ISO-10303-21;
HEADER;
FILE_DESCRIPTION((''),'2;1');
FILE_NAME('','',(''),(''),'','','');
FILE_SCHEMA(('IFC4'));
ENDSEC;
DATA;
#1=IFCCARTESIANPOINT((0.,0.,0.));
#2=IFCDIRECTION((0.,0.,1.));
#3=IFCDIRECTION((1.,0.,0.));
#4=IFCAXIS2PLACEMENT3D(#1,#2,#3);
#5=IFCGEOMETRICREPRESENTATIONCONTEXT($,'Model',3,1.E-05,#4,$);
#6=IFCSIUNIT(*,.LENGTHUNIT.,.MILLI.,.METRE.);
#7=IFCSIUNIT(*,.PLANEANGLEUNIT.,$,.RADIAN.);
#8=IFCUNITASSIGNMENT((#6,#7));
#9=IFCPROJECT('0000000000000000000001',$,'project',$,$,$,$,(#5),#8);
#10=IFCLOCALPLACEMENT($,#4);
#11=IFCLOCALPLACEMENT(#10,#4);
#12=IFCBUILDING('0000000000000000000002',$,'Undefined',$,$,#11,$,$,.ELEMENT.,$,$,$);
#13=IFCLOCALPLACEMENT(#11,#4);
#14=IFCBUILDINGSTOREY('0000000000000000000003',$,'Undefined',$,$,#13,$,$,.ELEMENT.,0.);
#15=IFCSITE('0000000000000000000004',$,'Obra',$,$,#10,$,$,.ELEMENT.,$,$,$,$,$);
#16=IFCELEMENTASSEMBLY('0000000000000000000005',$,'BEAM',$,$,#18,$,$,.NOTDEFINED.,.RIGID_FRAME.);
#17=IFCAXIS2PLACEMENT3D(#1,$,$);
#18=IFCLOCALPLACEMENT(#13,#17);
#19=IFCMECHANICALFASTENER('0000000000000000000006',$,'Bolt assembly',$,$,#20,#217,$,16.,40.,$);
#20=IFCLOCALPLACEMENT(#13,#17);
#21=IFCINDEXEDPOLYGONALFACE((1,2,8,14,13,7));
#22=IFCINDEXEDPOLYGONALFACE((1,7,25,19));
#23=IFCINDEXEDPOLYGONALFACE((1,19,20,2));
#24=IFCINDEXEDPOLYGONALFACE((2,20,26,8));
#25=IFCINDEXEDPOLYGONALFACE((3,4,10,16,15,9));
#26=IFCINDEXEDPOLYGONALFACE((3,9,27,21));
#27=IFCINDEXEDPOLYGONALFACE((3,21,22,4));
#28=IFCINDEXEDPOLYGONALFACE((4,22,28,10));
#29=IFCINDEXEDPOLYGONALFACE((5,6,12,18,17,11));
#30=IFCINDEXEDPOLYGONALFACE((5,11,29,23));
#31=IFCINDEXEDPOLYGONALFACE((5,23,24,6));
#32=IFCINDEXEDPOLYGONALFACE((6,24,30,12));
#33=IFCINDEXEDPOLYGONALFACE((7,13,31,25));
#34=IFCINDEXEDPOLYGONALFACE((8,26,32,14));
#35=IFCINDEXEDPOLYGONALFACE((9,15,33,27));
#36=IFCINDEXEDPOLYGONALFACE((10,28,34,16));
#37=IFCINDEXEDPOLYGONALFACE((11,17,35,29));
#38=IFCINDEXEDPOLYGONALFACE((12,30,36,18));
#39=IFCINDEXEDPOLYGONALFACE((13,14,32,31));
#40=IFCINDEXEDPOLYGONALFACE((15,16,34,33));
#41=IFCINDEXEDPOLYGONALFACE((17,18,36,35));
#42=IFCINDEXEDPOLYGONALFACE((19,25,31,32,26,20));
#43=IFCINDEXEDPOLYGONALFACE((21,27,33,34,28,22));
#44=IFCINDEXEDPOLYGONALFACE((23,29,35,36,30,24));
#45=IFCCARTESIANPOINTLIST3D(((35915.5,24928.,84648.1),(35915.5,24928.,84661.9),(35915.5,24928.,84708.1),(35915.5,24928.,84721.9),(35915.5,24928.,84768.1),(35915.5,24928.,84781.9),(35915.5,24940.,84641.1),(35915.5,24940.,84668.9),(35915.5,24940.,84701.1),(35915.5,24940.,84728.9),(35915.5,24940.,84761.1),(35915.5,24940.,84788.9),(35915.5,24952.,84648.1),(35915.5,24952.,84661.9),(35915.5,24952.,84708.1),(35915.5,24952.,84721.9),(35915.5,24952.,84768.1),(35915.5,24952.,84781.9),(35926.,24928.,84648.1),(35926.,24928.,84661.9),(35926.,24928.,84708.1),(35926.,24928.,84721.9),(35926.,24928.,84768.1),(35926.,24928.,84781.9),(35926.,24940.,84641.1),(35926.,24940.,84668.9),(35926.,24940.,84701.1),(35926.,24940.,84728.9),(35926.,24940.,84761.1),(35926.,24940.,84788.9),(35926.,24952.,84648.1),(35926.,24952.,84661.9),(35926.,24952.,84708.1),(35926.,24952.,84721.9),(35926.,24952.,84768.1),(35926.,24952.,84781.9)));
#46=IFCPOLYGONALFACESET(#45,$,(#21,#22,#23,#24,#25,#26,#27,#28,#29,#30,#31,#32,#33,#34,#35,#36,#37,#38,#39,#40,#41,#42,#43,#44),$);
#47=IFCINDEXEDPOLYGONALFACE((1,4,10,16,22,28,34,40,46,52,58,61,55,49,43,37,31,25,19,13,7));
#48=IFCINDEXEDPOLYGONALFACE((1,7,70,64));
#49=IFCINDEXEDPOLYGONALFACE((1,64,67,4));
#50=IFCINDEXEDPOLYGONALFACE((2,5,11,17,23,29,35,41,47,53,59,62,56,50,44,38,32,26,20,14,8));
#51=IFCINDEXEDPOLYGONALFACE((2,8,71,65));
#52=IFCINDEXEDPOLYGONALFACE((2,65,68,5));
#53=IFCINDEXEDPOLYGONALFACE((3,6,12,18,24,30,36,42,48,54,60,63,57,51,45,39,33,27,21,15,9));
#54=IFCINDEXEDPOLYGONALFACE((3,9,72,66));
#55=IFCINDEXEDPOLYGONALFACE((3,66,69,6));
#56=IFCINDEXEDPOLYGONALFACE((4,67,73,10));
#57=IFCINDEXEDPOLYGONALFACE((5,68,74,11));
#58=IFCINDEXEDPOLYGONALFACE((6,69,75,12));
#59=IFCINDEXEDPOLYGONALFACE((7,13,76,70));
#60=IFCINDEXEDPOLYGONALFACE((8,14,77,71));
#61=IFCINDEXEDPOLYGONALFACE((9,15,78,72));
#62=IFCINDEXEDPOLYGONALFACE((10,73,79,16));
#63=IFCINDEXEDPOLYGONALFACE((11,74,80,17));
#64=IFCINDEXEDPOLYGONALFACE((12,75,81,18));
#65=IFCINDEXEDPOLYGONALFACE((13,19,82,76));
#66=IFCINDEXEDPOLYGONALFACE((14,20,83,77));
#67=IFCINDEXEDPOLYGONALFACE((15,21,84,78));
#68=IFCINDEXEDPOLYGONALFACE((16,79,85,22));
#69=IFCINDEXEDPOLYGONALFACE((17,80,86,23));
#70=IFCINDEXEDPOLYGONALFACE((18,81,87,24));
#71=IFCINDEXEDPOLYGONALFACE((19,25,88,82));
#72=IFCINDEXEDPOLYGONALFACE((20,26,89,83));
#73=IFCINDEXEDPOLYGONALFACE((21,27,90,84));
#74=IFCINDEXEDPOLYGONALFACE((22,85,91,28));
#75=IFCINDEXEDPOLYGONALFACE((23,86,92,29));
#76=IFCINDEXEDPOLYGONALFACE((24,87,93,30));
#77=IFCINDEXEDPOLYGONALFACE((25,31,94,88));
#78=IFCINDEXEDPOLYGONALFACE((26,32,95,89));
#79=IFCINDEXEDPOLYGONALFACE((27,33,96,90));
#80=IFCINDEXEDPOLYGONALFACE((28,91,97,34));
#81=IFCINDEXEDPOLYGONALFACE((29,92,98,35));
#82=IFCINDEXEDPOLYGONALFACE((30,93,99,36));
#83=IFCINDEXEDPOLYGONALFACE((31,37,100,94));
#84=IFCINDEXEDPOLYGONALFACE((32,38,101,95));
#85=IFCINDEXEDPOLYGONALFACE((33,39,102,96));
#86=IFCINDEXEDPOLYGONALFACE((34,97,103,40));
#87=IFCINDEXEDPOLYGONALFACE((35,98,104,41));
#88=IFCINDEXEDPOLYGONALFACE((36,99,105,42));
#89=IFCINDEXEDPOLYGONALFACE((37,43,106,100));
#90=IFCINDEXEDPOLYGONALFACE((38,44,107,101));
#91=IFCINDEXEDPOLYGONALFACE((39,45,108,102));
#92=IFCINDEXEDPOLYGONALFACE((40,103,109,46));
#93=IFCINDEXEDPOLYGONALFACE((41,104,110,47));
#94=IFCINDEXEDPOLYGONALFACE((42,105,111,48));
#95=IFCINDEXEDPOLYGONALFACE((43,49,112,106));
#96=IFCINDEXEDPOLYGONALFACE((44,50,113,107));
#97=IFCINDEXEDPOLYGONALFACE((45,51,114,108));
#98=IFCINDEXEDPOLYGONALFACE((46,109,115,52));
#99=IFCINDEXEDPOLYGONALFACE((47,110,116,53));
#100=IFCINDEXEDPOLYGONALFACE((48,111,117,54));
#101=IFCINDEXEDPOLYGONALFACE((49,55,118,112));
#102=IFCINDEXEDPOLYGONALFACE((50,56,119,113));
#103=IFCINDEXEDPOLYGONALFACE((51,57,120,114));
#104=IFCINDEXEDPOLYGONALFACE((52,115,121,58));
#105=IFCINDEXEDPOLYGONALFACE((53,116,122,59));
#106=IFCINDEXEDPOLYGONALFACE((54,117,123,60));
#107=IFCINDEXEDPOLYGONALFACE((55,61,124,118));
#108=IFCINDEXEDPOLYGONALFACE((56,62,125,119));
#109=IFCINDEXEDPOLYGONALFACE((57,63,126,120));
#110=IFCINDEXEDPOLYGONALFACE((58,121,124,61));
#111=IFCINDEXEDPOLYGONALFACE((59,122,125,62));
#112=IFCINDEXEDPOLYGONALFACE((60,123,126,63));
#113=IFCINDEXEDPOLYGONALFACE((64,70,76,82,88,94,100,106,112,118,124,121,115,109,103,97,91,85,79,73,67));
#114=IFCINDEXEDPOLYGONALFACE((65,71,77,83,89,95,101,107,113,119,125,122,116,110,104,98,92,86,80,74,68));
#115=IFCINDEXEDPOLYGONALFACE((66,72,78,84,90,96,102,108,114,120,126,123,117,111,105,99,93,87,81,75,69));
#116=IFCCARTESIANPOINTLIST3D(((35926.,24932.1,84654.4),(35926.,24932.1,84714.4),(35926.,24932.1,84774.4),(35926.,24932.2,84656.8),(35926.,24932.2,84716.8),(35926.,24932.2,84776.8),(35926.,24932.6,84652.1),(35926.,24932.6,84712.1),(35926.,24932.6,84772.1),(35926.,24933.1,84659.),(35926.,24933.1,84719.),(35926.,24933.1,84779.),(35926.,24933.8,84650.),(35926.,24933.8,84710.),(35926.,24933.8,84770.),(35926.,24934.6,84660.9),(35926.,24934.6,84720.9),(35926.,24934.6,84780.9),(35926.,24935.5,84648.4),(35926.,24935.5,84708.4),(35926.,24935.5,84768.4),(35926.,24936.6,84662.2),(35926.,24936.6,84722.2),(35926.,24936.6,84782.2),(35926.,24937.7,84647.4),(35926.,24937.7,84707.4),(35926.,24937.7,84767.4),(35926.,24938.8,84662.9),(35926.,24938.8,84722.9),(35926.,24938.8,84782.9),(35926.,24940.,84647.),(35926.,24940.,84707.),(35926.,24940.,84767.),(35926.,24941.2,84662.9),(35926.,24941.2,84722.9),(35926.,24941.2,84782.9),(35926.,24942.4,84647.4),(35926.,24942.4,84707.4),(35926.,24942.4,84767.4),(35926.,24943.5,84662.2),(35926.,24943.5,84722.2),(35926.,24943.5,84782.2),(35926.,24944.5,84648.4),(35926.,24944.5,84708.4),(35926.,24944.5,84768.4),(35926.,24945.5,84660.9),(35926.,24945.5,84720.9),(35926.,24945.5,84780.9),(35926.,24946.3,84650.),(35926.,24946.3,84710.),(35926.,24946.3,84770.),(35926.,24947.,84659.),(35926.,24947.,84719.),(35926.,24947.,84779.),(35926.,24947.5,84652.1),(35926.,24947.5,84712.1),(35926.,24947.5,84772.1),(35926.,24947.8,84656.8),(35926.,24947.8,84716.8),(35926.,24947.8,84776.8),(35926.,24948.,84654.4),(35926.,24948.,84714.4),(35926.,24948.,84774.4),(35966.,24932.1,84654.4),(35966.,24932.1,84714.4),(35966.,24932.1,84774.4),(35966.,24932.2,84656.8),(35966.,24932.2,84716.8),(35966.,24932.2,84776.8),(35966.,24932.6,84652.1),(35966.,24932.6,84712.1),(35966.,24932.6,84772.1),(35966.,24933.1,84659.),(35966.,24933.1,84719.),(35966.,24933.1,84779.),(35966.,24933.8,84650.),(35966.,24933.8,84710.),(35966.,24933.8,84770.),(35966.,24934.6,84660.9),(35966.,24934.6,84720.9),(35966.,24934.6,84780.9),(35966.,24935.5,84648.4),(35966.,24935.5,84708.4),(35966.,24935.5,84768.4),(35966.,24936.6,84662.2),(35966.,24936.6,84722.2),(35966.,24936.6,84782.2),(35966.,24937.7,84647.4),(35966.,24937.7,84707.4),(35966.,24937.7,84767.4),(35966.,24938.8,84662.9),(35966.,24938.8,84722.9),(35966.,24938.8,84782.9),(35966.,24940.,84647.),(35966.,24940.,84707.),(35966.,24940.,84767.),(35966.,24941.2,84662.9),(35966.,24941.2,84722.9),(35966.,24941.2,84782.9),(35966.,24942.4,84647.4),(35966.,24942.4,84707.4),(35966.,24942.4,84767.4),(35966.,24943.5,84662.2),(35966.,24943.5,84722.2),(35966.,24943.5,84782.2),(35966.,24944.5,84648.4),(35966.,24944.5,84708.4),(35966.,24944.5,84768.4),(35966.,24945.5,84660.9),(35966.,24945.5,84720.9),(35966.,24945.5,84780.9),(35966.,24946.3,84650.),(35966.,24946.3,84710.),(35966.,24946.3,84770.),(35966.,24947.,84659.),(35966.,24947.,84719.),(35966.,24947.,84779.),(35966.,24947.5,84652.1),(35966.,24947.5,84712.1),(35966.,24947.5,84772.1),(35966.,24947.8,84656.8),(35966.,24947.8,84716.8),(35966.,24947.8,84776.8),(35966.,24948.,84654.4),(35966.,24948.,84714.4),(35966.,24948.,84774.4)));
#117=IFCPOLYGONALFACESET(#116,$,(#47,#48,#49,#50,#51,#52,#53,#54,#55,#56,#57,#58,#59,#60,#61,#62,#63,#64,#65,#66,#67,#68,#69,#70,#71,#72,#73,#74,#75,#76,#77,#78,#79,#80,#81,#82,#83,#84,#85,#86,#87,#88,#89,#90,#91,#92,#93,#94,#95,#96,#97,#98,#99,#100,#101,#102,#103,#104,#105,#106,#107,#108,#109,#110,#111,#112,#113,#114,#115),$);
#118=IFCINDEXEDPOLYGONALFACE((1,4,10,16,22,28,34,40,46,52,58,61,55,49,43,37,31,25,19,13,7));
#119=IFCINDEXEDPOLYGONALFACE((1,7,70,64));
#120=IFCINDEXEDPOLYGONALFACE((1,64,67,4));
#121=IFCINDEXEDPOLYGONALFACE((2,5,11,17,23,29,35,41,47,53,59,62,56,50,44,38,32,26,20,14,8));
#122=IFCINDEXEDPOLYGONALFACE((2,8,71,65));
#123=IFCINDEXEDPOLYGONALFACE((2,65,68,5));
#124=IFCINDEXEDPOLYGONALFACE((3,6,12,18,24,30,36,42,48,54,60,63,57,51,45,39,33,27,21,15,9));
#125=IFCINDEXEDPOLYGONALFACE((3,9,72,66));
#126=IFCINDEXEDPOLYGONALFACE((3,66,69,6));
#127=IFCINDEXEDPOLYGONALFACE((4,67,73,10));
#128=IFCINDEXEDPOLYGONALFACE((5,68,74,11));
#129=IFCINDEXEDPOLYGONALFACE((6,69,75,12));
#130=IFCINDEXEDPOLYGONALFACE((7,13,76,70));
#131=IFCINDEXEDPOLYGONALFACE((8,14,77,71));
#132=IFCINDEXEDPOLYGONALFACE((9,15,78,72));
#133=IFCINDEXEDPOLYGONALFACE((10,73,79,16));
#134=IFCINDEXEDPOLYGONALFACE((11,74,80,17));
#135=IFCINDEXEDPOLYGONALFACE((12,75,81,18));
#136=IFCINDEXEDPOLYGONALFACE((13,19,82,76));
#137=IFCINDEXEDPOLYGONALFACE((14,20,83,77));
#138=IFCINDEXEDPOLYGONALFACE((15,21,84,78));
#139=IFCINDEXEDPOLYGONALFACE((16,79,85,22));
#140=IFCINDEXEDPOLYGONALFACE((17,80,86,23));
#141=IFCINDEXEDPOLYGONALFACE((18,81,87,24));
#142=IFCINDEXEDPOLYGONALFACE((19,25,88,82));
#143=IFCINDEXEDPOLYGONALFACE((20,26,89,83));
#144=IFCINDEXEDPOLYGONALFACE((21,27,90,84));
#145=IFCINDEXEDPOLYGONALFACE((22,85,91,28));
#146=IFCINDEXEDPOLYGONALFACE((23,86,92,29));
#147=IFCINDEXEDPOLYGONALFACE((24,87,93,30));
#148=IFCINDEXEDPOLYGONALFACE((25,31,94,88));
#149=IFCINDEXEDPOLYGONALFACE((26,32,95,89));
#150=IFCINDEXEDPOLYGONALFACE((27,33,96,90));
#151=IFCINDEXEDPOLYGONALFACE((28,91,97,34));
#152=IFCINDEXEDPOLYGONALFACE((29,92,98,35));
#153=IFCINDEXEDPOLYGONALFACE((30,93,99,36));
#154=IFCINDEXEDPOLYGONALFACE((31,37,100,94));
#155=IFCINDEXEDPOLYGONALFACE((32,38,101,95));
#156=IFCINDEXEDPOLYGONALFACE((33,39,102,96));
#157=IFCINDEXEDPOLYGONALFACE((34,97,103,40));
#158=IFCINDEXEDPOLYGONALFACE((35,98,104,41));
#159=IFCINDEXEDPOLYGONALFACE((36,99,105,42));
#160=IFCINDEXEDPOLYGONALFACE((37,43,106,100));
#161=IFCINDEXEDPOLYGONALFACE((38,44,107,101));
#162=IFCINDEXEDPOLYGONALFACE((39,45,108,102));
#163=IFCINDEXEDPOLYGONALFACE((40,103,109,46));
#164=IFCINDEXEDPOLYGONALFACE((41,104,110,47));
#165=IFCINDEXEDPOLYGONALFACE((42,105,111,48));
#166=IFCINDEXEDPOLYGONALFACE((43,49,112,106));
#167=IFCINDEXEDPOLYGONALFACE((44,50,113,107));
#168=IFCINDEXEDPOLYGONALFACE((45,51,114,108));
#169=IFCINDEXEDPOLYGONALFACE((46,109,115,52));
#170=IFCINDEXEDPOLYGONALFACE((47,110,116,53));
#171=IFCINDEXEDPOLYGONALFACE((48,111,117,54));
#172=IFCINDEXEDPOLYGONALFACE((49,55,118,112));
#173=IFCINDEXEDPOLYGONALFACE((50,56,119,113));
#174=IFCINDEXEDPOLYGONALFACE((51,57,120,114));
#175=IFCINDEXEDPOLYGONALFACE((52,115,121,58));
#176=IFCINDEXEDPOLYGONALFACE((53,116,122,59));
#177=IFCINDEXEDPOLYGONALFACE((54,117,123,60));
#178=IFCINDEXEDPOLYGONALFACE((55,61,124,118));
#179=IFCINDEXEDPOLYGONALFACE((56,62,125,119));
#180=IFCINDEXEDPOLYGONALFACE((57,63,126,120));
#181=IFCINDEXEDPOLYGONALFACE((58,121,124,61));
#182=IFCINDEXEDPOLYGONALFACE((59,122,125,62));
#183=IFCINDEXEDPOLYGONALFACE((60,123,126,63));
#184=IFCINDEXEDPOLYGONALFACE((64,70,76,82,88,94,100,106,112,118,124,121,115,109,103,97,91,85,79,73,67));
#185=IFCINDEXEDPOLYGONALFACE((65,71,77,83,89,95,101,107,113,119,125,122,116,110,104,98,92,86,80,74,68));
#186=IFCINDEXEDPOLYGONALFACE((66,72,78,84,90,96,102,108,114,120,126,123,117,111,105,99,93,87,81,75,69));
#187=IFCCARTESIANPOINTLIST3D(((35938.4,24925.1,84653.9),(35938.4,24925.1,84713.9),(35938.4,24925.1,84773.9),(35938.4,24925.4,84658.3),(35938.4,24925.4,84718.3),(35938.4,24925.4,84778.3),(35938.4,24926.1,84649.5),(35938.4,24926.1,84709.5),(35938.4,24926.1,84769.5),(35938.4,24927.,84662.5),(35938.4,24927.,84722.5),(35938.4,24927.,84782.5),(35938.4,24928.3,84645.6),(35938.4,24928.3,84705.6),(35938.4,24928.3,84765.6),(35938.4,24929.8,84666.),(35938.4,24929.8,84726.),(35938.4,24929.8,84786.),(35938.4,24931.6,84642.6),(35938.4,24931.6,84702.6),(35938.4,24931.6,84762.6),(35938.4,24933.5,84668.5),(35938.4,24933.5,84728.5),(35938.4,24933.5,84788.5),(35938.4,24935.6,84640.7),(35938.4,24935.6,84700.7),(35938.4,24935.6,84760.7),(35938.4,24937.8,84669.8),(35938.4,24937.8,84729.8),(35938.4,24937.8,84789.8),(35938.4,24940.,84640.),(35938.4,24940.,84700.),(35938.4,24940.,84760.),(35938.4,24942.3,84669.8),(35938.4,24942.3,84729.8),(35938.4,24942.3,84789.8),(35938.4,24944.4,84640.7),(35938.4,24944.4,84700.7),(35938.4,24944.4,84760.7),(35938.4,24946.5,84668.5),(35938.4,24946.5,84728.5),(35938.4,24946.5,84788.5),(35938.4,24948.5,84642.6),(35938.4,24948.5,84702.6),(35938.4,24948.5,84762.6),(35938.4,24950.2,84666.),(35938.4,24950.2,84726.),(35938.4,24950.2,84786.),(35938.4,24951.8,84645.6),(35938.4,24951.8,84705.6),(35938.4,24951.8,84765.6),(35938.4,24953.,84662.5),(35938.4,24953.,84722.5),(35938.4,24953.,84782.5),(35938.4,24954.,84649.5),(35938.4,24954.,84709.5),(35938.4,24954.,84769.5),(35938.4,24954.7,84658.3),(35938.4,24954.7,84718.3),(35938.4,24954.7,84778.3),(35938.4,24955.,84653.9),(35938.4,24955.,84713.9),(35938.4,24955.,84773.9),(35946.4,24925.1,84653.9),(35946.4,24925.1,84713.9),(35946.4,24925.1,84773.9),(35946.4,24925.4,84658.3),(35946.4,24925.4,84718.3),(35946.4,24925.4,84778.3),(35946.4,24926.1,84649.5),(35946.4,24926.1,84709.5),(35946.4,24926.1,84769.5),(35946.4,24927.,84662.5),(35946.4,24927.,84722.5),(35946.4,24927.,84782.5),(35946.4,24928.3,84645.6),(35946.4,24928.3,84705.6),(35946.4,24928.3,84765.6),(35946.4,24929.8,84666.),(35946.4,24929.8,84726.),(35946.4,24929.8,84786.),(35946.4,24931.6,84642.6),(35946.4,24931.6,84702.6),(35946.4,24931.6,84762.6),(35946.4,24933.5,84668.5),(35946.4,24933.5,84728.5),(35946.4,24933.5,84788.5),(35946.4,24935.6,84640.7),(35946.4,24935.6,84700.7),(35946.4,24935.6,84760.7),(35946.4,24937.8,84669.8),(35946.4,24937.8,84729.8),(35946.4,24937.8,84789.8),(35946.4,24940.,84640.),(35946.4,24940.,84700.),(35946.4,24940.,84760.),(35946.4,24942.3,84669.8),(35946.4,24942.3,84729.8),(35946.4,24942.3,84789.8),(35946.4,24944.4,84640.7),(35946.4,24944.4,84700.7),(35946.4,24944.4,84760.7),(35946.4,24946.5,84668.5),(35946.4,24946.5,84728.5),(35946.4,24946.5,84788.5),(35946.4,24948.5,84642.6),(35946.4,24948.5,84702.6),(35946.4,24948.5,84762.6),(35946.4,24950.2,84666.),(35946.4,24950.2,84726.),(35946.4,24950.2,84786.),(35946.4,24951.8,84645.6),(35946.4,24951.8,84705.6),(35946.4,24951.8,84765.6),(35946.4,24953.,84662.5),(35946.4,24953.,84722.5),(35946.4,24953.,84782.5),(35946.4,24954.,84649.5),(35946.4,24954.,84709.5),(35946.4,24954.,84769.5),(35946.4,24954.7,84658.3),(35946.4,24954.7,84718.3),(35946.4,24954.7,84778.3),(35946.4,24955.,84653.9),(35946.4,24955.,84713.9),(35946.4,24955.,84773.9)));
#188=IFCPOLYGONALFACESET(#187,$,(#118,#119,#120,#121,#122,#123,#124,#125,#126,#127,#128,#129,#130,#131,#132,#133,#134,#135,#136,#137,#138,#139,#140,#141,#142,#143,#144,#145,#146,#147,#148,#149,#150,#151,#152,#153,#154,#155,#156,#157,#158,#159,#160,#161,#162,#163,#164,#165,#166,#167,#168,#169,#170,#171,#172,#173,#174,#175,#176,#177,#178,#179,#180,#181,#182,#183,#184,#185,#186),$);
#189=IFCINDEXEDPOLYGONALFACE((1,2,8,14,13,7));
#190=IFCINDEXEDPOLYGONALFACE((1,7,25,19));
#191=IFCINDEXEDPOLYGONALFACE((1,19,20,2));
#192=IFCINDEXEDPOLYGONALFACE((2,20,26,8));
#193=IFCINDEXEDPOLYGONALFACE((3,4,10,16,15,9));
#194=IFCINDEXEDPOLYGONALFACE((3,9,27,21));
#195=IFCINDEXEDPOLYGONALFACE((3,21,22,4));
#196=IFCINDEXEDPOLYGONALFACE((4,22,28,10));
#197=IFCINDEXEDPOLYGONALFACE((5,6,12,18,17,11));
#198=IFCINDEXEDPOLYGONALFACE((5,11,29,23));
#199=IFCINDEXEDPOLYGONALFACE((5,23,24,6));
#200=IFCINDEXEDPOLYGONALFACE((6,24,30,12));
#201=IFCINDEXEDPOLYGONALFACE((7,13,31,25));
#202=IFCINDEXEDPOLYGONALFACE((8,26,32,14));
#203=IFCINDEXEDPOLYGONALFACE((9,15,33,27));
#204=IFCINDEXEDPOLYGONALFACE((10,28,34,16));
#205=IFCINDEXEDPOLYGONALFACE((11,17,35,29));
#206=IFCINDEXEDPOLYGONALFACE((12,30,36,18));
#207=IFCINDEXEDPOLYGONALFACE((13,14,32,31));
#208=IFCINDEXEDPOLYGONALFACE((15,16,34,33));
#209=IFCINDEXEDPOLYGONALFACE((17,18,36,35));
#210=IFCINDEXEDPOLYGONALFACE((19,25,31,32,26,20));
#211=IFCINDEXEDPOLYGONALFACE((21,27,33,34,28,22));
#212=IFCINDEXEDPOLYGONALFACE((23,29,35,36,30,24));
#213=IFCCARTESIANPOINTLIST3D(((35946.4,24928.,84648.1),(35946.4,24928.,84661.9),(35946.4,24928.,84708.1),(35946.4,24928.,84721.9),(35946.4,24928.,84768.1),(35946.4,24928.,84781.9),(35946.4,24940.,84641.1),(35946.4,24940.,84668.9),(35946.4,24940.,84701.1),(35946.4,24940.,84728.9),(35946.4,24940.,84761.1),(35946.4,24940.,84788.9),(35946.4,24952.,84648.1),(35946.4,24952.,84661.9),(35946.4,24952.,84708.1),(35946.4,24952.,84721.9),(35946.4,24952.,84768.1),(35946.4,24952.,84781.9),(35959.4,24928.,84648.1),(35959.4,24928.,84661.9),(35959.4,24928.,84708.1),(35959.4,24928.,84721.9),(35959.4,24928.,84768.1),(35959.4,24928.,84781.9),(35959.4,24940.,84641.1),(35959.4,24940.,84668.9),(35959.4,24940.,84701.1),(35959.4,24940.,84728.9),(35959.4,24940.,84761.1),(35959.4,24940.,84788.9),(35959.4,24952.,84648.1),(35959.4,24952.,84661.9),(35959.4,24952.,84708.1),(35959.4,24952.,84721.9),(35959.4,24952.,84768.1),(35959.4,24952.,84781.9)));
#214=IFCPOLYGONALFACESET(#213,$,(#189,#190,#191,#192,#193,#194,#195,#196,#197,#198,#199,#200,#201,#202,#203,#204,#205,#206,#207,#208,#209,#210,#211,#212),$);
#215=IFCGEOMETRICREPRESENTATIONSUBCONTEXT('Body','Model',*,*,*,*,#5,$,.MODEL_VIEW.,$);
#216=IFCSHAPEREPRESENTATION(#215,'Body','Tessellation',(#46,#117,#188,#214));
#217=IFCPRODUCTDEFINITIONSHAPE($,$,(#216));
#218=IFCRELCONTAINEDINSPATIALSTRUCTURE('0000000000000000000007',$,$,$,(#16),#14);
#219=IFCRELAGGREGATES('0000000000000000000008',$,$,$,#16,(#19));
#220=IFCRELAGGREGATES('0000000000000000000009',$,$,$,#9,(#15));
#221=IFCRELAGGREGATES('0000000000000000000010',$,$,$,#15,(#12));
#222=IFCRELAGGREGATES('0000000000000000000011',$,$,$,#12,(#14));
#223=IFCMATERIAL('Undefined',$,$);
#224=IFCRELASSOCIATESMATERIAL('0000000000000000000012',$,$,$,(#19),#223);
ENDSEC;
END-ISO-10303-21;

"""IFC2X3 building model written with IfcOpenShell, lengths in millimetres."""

from ifc_helpers import new_model, si_unit, frame, origin_with_axes, origin_2d_with_axis, place, context, subcontext, project, spatial, polyline, circle, outline, extrude, source, transform, mapped, material, element, aggregate, save


model = new_model("IFC2X3")

# Units and contexts
model_context = context("Model", 3, precision=1e-05, world=origin_with_axes())
body_context = subcontext(model_context, "Body", "Model", "MODEL_VIEW")
ifc_project = project(units=[si_unit("LENGTHUNIT", "METRE", prefix="MILLI"), si_unit("PLANEANGLEUNIT", "RADIAN")], contexts=[model_context])

# Site, building, storey
site_placement = place(None, origin_with_axes())
site = spatial("IfcSite", under=ifc_project, at=site_placement, Name="Obra", CompositionType="ELEMENT")
building_placement = place(site_placement, origin_with_axes())
building = spatial("IfcBuilding", under=site, at=building_placement, Name="Undefined", CompositionType="ELEMENT")
storey_placement = place(building_placement, origin_with_axes())
storey = spatial("IfcBuildingStorey", under=building, at=storey_placement, Name="Undefined", CompositionType="ELEMENT", Elevation=0.0)

# Element assembly
ifc_material_1 = material(Name="Undefined")
assembly_1_placement = place(storey_placement, origin_with_axes())
assembly_1 = element("IfcElementAssembly", 1, at=assembly_1_placement, inside=storey, Name="BEAM", AssemblyPlace="NOTDEFINED", PredefinedType="RIGID_FRAME")

# Shared definitions
shared_shape_1 = source(origin_with_axes(), body_context, "Body", "SweptSolid", [
    extrude(outline(polyline([(13.9, 0.0), (6.9, 12.0), (-6.9, 12.0), (-13.9, 0.0), (-6.9, -12.0), (6.9, -12.0), (13.9, 0.0)])), frame((0.0, -19.7, 0.0), z_axis=(0.0, 1.0, 0.0), x_axis=(1.0, 0.0, 0.0)), (0.0, 0.0, 1.0), 10.6),
    extrude(circle(Radius=8.0, at=origin_2d_with_axis()), frame((0.0, -9.1, 0.0), z_axis=(0.0, 1.0, 0.0), x_axis=(1.0, 0.0, 0.0)), (0.0, 0.0, 1.0), 40.0),
    extrude(circle(Radius=15.0, at=origin_2d_with_axis()), frame((0.0, 3.3, 0.0), z_axis=(0.0, 1.0, 0.0), x_axis=(1.0, 0.0, 0.0)), (0.0, 0.0, 1.0), 8.0),
    extrude(outline(polyline([(13.9, 0.0), (6.9, 12.0), (-6.9, 12.0), (-13.9, 0.0), (-6.9, -12.0), (6.9, -12.0), (13.9, 0.0)])), frame((0.0, 11.3, 0.0), z_axis=(0.0, 1.0, 0.0), x_axis=(1.0, 0.0, 0.0)), (0.0, 0.0, 1.0), 13.0),
])

# Mechanical fastener
mechanical_fastener_1_placement = place(assembly_1_placement, frame((35935.1, 24990.0, 84835.0), z_axis=(0.000002, -1.0, 0.0), x_axis=(0.0, 0.0, -1.0)))
mechanical_fastener_1 = element("IfcMechanicalFastener", 2, at=mechanical_fastener_1_placement, material=ifc_material_1, Name="Bolt assembly", NominalDiameter=16.0, NominalLength=40.0, context=body_context, shape_type="MappedRepresentation", body=[
    mapped(shared_shape_1, transform((60.0, 0.0, 50.0))),
    mapped(shared_shape_1, transform((120.0, 0.0, 50.0))),
    mapped(shared_shape_1, transform((180.0, 0.0, 50.0))),
])
aggregate(assembly_1, [mechanical_fastener_1])

save(model, "model.ifc")
